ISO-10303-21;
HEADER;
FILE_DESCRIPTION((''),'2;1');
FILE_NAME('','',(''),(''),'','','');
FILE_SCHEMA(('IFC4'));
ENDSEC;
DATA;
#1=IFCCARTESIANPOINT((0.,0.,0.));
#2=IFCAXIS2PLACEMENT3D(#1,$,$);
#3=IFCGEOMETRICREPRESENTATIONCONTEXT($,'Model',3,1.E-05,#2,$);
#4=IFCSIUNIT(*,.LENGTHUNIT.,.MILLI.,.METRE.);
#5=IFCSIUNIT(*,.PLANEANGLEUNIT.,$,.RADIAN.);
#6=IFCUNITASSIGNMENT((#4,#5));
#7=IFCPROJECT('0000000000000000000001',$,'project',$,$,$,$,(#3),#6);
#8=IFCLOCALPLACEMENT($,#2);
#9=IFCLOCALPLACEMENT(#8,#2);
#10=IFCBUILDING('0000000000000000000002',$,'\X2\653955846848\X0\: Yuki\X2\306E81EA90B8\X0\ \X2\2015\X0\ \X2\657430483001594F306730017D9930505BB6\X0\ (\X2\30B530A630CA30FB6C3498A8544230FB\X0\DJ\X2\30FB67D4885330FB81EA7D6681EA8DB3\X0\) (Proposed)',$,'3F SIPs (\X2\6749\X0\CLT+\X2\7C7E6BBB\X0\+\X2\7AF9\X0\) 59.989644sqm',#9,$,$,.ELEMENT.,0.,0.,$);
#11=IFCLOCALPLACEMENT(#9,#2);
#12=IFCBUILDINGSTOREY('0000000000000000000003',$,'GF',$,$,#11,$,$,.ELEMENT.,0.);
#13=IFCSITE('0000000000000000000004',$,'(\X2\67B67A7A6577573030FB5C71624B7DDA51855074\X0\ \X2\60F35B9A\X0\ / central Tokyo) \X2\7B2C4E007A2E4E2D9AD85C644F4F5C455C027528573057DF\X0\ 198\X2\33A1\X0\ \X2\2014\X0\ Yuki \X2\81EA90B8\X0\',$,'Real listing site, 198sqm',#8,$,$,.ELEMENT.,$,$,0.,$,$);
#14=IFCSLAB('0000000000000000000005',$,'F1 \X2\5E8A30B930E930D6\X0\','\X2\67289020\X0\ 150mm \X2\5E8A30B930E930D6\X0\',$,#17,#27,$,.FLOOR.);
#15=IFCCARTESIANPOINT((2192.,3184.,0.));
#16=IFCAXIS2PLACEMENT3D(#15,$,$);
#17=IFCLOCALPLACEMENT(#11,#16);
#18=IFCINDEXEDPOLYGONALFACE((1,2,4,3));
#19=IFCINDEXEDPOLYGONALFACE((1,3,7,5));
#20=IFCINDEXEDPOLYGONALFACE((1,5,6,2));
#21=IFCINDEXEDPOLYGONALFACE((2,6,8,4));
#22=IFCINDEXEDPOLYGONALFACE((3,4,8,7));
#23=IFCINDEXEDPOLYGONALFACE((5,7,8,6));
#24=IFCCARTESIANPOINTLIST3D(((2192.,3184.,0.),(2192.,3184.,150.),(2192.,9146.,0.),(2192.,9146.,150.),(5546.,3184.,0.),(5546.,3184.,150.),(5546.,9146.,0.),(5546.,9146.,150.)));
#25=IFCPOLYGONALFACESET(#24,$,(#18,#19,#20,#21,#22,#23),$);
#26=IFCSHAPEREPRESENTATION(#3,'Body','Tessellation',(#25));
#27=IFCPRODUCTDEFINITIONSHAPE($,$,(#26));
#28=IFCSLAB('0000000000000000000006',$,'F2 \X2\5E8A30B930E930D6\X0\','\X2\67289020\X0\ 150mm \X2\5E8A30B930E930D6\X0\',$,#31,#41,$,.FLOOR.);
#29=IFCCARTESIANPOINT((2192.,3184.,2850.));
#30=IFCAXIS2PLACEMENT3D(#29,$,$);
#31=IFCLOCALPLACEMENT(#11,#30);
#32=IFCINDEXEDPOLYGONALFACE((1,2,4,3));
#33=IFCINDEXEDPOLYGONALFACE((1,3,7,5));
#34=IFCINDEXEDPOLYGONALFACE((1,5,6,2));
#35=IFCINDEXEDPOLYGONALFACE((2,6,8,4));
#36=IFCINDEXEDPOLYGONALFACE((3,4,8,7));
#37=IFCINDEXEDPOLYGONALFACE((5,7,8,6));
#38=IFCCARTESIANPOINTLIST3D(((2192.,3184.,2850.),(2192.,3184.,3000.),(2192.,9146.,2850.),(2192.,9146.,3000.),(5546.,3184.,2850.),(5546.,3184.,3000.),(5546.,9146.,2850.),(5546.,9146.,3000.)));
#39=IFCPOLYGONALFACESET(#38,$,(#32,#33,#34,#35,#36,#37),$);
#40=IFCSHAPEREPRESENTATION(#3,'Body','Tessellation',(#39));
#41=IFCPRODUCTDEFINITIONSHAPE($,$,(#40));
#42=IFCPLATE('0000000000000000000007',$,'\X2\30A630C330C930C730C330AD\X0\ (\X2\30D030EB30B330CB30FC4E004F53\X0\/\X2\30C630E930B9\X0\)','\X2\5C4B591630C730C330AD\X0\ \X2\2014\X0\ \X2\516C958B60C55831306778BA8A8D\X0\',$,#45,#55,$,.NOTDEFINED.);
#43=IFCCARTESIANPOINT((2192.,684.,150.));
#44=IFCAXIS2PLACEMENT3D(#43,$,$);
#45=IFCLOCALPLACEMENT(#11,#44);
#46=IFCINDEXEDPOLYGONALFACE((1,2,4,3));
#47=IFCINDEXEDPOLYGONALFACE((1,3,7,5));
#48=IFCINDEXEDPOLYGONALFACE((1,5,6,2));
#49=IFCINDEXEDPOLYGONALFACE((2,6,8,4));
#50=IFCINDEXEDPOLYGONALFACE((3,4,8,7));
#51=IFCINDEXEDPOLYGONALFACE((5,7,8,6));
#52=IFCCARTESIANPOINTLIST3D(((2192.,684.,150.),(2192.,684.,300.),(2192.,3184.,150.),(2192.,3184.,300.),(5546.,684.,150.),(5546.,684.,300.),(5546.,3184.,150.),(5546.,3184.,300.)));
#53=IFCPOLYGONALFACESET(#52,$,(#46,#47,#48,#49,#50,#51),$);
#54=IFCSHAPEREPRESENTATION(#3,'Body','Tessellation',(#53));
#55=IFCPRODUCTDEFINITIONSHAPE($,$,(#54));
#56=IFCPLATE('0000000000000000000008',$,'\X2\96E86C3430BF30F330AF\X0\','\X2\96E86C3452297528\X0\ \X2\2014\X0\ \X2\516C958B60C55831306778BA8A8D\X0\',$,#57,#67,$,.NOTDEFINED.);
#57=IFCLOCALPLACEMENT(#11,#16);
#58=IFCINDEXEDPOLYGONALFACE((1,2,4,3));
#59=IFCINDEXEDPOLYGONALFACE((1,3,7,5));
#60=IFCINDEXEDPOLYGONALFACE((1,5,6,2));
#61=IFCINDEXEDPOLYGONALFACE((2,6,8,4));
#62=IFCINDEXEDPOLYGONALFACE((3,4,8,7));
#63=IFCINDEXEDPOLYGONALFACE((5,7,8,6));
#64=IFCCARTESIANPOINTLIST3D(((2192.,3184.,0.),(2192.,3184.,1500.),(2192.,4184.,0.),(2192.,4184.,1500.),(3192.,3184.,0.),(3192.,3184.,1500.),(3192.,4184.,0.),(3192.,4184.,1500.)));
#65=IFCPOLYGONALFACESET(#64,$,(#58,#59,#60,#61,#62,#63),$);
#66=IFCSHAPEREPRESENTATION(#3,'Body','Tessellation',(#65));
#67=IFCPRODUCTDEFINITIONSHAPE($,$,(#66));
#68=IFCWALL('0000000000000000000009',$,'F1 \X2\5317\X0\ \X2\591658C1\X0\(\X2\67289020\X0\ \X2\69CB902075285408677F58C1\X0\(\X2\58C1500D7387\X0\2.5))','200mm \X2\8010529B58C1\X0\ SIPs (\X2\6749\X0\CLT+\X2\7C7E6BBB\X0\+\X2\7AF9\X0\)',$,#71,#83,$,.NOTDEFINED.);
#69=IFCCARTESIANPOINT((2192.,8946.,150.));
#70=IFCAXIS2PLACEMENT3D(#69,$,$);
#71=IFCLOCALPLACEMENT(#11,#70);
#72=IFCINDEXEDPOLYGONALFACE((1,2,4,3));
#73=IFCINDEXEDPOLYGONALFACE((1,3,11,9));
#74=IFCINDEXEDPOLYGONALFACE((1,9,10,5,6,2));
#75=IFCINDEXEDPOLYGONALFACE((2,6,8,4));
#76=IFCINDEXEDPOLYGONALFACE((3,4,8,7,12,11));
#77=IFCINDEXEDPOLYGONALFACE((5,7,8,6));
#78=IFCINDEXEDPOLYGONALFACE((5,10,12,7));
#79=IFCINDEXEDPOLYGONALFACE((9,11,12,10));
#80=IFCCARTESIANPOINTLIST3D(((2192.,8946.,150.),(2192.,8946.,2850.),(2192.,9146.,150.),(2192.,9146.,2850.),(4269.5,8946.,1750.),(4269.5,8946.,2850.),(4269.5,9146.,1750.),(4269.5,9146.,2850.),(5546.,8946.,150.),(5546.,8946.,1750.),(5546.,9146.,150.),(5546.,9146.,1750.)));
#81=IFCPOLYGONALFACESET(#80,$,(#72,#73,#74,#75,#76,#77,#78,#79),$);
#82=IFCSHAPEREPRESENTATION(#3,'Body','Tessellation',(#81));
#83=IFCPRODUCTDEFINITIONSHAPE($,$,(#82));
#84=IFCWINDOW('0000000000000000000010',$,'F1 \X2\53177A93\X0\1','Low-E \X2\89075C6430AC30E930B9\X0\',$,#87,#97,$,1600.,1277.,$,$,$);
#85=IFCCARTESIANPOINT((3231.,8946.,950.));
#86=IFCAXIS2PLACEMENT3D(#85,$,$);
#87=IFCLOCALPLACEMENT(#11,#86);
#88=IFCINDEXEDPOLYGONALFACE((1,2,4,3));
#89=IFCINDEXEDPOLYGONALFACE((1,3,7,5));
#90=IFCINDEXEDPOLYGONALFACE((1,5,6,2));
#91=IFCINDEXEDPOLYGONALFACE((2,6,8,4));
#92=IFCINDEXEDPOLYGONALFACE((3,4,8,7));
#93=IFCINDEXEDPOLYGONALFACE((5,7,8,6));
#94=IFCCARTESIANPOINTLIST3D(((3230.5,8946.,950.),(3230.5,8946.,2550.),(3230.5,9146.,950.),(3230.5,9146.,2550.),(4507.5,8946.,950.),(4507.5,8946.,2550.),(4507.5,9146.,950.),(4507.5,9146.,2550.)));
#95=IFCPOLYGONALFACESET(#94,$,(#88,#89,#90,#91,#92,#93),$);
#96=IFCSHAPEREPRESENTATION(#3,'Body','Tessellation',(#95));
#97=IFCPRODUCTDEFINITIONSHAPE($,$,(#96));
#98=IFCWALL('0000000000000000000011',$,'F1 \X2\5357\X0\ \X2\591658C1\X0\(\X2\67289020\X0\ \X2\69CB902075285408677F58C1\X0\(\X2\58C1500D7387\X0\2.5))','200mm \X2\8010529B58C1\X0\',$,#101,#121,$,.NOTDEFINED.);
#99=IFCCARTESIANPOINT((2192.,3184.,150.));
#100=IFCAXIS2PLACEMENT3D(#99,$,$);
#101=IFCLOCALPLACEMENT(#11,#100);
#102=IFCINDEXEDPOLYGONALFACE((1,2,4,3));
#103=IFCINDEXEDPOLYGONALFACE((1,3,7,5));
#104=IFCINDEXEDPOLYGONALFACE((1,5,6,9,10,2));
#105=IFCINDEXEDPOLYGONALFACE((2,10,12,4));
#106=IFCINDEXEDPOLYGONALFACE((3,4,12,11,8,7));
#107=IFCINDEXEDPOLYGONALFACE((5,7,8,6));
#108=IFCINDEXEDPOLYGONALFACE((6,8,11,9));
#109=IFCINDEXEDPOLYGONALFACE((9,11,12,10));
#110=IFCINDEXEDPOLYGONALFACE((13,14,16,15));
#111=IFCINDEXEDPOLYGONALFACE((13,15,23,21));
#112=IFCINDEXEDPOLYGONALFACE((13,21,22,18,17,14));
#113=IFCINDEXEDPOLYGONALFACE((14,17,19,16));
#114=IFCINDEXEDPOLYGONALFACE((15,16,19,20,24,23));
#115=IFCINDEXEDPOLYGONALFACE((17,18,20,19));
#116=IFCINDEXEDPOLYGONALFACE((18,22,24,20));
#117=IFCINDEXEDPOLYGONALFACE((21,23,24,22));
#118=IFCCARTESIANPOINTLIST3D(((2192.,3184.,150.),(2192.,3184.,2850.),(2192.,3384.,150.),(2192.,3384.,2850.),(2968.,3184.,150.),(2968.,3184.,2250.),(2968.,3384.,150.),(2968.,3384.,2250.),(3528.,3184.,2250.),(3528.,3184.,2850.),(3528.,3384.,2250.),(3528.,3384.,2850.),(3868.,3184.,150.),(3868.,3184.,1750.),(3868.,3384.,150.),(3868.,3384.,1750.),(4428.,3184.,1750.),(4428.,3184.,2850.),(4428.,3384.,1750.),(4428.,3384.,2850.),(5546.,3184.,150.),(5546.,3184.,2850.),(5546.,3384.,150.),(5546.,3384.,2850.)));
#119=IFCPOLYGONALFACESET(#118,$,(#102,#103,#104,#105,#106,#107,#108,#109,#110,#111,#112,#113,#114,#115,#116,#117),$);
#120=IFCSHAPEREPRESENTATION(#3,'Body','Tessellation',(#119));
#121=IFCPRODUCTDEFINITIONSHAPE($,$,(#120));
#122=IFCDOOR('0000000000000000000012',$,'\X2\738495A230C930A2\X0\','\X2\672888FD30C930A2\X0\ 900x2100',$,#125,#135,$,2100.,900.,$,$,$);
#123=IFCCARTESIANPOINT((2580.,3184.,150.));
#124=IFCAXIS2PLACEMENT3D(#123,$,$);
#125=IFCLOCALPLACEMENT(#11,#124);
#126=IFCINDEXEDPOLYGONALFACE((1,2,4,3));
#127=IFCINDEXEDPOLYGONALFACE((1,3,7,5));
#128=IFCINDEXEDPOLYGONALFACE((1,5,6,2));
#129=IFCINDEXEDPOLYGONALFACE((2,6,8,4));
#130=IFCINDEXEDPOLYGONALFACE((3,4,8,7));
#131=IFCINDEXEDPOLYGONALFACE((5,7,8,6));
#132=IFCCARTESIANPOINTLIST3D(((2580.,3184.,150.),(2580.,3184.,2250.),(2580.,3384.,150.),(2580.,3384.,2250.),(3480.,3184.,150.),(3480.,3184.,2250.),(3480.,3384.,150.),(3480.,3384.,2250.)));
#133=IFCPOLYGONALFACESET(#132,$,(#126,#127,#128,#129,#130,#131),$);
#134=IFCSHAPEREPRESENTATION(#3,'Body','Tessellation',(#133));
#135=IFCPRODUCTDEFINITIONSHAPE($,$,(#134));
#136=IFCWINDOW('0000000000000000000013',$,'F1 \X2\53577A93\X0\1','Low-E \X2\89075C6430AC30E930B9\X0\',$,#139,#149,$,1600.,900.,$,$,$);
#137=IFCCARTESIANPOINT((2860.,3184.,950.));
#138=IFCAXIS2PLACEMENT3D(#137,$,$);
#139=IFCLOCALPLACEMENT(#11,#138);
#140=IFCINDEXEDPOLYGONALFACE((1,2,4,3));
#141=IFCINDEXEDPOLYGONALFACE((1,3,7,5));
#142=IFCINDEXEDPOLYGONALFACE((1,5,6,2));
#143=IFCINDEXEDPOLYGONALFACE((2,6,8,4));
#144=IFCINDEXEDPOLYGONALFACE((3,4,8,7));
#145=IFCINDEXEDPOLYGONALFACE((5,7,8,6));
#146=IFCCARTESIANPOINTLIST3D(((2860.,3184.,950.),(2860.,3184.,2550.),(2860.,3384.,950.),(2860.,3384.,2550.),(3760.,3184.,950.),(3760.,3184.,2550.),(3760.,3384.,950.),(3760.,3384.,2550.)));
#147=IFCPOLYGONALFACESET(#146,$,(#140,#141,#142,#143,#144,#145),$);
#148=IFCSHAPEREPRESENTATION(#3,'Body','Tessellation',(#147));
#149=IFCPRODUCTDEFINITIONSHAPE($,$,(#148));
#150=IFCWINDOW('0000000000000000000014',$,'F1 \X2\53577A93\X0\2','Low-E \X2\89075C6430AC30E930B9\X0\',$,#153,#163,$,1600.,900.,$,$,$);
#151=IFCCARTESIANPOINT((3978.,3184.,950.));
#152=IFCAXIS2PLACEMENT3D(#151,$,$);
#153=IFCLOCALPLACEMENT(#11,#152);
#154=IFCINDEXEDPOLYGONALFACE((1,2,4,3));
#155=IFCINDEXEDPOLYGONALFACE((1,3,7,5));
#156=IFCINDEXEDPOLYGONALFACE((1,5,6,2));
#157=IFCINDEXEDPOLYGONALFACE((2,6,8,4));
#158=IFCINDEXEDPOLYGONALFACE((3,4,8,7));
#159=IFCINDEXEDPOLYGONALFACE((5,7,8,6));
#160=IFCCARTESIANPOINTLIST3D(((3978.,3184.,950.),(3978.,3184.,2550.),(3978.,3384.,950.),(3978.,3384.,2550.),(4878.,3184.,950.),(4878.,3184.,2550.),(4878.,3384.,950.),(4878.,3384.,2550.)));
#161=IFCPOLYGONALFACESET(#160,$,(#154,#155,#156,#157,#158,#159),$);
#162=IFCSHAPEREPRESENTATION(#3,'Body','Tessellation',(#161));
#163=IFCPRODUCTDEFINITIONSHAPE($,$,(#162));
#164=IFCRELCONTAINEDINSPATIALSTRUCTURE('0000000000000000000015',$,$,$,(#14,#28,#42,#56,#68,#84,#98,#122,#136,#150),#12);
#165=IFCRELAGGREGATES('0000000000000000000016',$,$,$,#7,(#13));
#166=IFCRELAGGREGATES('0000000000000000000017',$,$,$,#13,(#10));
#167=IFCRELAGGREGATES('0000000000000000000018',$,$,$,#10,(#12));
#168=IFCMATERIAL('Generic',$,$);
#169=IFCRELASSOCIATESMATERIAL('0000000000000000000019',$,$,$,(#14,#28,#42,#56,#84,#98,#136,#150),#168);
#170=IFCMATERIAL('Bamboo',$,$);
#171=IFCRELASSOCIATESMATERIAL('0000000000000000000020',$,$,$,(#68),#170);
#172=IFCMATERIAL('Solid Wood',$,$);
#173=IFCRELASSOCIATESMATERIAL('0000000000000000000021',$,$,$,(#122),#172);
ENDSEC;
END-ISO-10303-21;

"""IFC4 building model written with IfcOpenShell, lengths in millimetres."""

from ifc_helpers import new_model, si_unit, frame, frame_2d, origin, place, context, project, spatial, rectangle, extrude, material, element, fill, save


model = new_model("IFC4")

# Units and contexts
model_context = context("Model", 3, precision=1e-05, world=origin())
ifc_project = project(units=[si_unit("LENGTHUNIT", "METRE", prefix="MILLI"), si_unit("PLANEANGLEUNIT", "RADIAN")], contexts=[model_context])

# Site, building, storey
site_placement = place(None, origin())
site = spatial("IfcSite", under=ifc_project, at=site_placement, Name="(架空敷地・山手線内側 想定 / central Tokyo) 第一種中高層住居専用地域 198㎡ — Yuki 自邸", ObjectType="Real listing site, 198sqm", CompositionType="ELEMENT", RefElevation=0.0)
building_placement = place(site_placement, origin())
building = spatial("IfcBuilding", under=site, at=building_placement, Name="改善案: Yukiの自邸 ― 整え、奏で、継ぐ家 (サウナ・水風呂・DJ・柔術・自給自足) (Proposed)", ObjectType="3F SIPs (杉CLT+籾殻+竹) 59.989644sqm", CompositionType="ELEMENT", ElevationOfRefHeight=0.0, ElevationOfTerrain=0.0)
storey_placement = place(building_placement, origin())
storey = spatial("IfcBuildingStorey", under=building, at=storey_placement, Name="GF", CompositionType="ELEMENT", Elevation=0.0)

# Slabs
ifc_material_1 = material(Name="Generic")
slab_1_placement = place(storey_placement, frame((2192.0, 3184.0, 0.0)))
element("IfcSlab", 1, at=slab_1_placement, inside=storey, material=ifc_material_1, Name="F1 床スラブ", Description="木造 150mm 床スラブ", PredefinedType="FLOOR", context=model_context, shape_type="SweptSolid", body=[
    extrude(rectangle(XDim=3354.0, YDim=5962.0, at=frame_2d((1677.0, 2981.0))), frame((2192.0, 3184.0, 0.0)), (0.0, 0.0, 1.0), 150.0),
])
slab_2_placement = place(storey_placement, frame((2192.0, 3184.0, 2850.0)))
element("IfcSlab", 2, at=slab_2_placement, inside=storey, material=ifc_material_1, Name="F2 床スラブ", Description="木造 150mm 床スラブ", PredefinedType="FLOOR", context=model_context, shape_type="SweptSolid", body=[
    extrude(rectangle(XDim=3354.0, YDim=5962.0, at=frame_2d((1677.0, 2981.0))), frame((2192.0, 3184.0, 2850.0)), (0.0, 0.0, 1.0), 150.0),
])

# Plates
plate_1_placement = place(storey_placement, frame((2192.0, 684.0, 150.0)))
element("IfcPlate", 3, at=plate_1_placement, inside=storey, material=ifc_material_1, Name="ウッドデッキ (バルコニー一体/テラス)", Description="屋外デッキ — 公開情報で確認", PredefinedType="NOTDEFINED", context=model_context, shape_type="SweptSolid", body=[
    extrude(rectangle(XDim=3354.0, YDim=2500.0, at=frame_2d((1677.0, 1250.0))), frame((2192.0, 684.0, 150.0)), (0.0, 0.0, 1.0), 150.0),
])
plate_2_placement = place(storey_placement, frame((2192.0, 3184.0, 0.0)))
element("IfcPlate", 4, at=plate_2_placement, inside=storey, material=ifc_material_1, Name="雨水タンク", Description="雨水利用 — 公開情報で確認", PredefinedType="NOTDEFINED", context=model_context, shape_type="SweptSolid", body=[
    extrude(rectangle(XDim=1000.0, YDim=1000.0, at=frame_2d((500.0, 500.0))), frame((2192.0, 3184.0, 0.0)), (0.0, 0.0, 1.0), 1500.0),
])

# Wall, opening, window
ifc_material_2 = material(Name="Bamboo")
wall_1_placement = place(storey_placement, frame((2192.0, 8946.0, 150.0)))
wall_1 = element("IfcWall", 5, at=wall_1_placement, inside=storey, material=ifc_material_2, Name="F1 北 外壁(木造 構造用合板壁(壁倍率2.5))", Description="200mm 耐力壁 SIPs (杉CLT+籾殻+竹)", PredefinedType="NOTDEFINED", context=model_context, shape_type="SweptSolid", body=[
    extrude(rectangle(XDim=3354.0, YDim=200.0, at=frame_2d((1677.0, 100.0))), frame((2192.0, 8946.0, 150.0)), (0.0, 0.0, 1.0), 2700.0),
])
opening_1_placement = place(storey_placement, frame((3231.0, 8946.0, 950.0)))
opening_1 = element("IfcOpeningElement", 6, at=opening_1_placement, cuts=wall_1, PredefinedType="NOTDEFINED", context=model_context, shape_type="SweptSolid", body=[
    extrude(rectangle(XDim=1277.0, YDim=200.0, at=frame_2d((638.0, 100.0))), frame((3231.0, 8946.0, 950.0)), (0.0, 0.0, 1.0), 1600.0),
])
window_1_placement = place(storey_placement, frame((3231.0, 8946.0, 950.0)))
window_1 = element("IfcWindow", 7, at=window_1_placement, inside=storey, material=ifc_material_1, Name="F1 北窓1", Description="Low-E 複層ガラス", OverallHeight=1600.0, OverallWidth=1277.0, context=model_context, shape_type="SweptSolid", body=[
    extrude(rectangle(XDim=1277.0, YDim=200.0, at=frame_2d((638.0, 100.0))), frame((3231.0, 8946.0, 950.0)), (0.0, 0.0, 1.0), 1600.0),
])
fill(opening_1, window_1)

# Wall, openings, door, windows
wall_2_placement = place(storey_placement, frame((2192.0, 3184.0, 150.0)))
wall_2 = element("IfcWall", 8, at=wall_2_placement, inside=storey, material=ifc_material_1, Name="F1 南 外壁(木造 構造用合板壁(壁倍率2.5))", Description="200mm 耐力壁", PredefinedType="NOTDEFINED", context=model_context, shape_type="SweptSolid", body=[
    extrude(rectangle(XDim=3354.0, YDim=200.0, at=frame_2d((1677.0, 100.0))), frame((2192.0, 3184.0, 150.0)), (0.0, 0.0, 1.0), 2700.0),
])
opening_2_placement = place(storey_placement, frame((2580.0, 3184.0, 150.0)))
opening_2 = element("IfcOpeningElement", 9, at=opening_2_placement, cuts=wall_2, PredefinedType="NOTDEFINED", context=model_context, shape_type="SweptSolid", body=[
    extrude(rectangle(XDim=900.0, YDim=200.0, at=frame_2d((450.0, 100.0))), frame((2580.0, 3184.0, 150.0)), (0.0, 0.0, 1.0), 2100.0),
])
opening_3_placement = place(storey_placement, frame((2860.0, 3184.0, 950.0)))
opening_3 = element("IfcOpeningElement", 10, at=opening_3_placement, cuts=wall_2, PredefinedType="NOTDEFINED", context=model_context, shape_type="SweptSolid", body=[
    extrude(rectangle(XDim=900.0, YDim=200.0, at=frame_2d((450.0, 100.0))), frame((2860.0, 3184.0, 950.0)), (0.0, 0.0, 1.0), 1600.0),
])
opening_4_placement = place(storey_placement, frame((3978.0, 3184.0, 950.0)))
opening_4 = element("IfcOpeningElement", 11, at=opening_4_placement, cuts=wall_2, PredefinedType="NOTDEFINED", context=model_context, shape_type="SweptSolid", body=[
    extrude(rectangle(XDim=900.0, YDim=200.0, at=frame_2d((450.0, 100.0))), frame((3978.0, 3184.0, 950.0)), (0.0, 0.0, 1.0), 1600.0),
])
ifc_material_3 = material(Name="Solid Wood")
door_placement = place(storey_placement, frame((2580.0, 3184.0, 150.0)))
door = element("IfcDoor", 12, at=door_placement, inside=storey, material=ifc_material_3, Name="玄関ドア", Description="木製ドア 900x2100", OverallHeight=2100.0, OverallWidth=900.0, context=model_context, shape_type="SweptSolid", body=[
    extrude(rectangle(XDim=900.0, YDim=200.0, at=frame_2d((450.0, 100.0))), frame((2580.0, 3184.0, 150.0)), (0.0, 0.0, 1.0), 2100.0),
])
fill(opening_2, door)
window_2_placement = place(storey_placement, frame((2860.0, 3184.0, 950.0)))
window_2 = element("IfcWindow", 13, at=window_2_placement, inside=storey, material=ifc_material_1, Name="F1 南窓1", Description="Low-E 複層ガラス", OverallHeight=1600.0, OverallWidth=900.0, context=model_context, shape_type="SweptSolid", body=[
    extrude(rectangle(XDim=900.0, YDim=200.0, at=frame_2d((450.0, 100.0))), frame((2860.0, 3184.0, 950.0)), (0.0, 0.0, 1.0), 1600.0),
])
fill(opening_3, window_2)
window_3_placement = place(storey_placement, frame((3978.0, 3184.0, 950.0)))
window_3 = element("IfcWindow", 14, at=window_3_placement, inside=storey, material=ifc_material_1, Name="F1 南窓2", Description="Low-E 複層ガラス", OverallHeight=1600.0, OverallWidth=900.0, context=model_context, shape_type="SweptSolid", body=[
    extrude(rectangle(XDim=900.0, YDim=200.0, at=frame_2d((450.0, 100.0))), frame((3978.0, 3184.0, 950.0)), (0.0, 0.0, 1.0), 1600.0),
])
fill(opening_4, window_3)

save(model, "model.ifc")
